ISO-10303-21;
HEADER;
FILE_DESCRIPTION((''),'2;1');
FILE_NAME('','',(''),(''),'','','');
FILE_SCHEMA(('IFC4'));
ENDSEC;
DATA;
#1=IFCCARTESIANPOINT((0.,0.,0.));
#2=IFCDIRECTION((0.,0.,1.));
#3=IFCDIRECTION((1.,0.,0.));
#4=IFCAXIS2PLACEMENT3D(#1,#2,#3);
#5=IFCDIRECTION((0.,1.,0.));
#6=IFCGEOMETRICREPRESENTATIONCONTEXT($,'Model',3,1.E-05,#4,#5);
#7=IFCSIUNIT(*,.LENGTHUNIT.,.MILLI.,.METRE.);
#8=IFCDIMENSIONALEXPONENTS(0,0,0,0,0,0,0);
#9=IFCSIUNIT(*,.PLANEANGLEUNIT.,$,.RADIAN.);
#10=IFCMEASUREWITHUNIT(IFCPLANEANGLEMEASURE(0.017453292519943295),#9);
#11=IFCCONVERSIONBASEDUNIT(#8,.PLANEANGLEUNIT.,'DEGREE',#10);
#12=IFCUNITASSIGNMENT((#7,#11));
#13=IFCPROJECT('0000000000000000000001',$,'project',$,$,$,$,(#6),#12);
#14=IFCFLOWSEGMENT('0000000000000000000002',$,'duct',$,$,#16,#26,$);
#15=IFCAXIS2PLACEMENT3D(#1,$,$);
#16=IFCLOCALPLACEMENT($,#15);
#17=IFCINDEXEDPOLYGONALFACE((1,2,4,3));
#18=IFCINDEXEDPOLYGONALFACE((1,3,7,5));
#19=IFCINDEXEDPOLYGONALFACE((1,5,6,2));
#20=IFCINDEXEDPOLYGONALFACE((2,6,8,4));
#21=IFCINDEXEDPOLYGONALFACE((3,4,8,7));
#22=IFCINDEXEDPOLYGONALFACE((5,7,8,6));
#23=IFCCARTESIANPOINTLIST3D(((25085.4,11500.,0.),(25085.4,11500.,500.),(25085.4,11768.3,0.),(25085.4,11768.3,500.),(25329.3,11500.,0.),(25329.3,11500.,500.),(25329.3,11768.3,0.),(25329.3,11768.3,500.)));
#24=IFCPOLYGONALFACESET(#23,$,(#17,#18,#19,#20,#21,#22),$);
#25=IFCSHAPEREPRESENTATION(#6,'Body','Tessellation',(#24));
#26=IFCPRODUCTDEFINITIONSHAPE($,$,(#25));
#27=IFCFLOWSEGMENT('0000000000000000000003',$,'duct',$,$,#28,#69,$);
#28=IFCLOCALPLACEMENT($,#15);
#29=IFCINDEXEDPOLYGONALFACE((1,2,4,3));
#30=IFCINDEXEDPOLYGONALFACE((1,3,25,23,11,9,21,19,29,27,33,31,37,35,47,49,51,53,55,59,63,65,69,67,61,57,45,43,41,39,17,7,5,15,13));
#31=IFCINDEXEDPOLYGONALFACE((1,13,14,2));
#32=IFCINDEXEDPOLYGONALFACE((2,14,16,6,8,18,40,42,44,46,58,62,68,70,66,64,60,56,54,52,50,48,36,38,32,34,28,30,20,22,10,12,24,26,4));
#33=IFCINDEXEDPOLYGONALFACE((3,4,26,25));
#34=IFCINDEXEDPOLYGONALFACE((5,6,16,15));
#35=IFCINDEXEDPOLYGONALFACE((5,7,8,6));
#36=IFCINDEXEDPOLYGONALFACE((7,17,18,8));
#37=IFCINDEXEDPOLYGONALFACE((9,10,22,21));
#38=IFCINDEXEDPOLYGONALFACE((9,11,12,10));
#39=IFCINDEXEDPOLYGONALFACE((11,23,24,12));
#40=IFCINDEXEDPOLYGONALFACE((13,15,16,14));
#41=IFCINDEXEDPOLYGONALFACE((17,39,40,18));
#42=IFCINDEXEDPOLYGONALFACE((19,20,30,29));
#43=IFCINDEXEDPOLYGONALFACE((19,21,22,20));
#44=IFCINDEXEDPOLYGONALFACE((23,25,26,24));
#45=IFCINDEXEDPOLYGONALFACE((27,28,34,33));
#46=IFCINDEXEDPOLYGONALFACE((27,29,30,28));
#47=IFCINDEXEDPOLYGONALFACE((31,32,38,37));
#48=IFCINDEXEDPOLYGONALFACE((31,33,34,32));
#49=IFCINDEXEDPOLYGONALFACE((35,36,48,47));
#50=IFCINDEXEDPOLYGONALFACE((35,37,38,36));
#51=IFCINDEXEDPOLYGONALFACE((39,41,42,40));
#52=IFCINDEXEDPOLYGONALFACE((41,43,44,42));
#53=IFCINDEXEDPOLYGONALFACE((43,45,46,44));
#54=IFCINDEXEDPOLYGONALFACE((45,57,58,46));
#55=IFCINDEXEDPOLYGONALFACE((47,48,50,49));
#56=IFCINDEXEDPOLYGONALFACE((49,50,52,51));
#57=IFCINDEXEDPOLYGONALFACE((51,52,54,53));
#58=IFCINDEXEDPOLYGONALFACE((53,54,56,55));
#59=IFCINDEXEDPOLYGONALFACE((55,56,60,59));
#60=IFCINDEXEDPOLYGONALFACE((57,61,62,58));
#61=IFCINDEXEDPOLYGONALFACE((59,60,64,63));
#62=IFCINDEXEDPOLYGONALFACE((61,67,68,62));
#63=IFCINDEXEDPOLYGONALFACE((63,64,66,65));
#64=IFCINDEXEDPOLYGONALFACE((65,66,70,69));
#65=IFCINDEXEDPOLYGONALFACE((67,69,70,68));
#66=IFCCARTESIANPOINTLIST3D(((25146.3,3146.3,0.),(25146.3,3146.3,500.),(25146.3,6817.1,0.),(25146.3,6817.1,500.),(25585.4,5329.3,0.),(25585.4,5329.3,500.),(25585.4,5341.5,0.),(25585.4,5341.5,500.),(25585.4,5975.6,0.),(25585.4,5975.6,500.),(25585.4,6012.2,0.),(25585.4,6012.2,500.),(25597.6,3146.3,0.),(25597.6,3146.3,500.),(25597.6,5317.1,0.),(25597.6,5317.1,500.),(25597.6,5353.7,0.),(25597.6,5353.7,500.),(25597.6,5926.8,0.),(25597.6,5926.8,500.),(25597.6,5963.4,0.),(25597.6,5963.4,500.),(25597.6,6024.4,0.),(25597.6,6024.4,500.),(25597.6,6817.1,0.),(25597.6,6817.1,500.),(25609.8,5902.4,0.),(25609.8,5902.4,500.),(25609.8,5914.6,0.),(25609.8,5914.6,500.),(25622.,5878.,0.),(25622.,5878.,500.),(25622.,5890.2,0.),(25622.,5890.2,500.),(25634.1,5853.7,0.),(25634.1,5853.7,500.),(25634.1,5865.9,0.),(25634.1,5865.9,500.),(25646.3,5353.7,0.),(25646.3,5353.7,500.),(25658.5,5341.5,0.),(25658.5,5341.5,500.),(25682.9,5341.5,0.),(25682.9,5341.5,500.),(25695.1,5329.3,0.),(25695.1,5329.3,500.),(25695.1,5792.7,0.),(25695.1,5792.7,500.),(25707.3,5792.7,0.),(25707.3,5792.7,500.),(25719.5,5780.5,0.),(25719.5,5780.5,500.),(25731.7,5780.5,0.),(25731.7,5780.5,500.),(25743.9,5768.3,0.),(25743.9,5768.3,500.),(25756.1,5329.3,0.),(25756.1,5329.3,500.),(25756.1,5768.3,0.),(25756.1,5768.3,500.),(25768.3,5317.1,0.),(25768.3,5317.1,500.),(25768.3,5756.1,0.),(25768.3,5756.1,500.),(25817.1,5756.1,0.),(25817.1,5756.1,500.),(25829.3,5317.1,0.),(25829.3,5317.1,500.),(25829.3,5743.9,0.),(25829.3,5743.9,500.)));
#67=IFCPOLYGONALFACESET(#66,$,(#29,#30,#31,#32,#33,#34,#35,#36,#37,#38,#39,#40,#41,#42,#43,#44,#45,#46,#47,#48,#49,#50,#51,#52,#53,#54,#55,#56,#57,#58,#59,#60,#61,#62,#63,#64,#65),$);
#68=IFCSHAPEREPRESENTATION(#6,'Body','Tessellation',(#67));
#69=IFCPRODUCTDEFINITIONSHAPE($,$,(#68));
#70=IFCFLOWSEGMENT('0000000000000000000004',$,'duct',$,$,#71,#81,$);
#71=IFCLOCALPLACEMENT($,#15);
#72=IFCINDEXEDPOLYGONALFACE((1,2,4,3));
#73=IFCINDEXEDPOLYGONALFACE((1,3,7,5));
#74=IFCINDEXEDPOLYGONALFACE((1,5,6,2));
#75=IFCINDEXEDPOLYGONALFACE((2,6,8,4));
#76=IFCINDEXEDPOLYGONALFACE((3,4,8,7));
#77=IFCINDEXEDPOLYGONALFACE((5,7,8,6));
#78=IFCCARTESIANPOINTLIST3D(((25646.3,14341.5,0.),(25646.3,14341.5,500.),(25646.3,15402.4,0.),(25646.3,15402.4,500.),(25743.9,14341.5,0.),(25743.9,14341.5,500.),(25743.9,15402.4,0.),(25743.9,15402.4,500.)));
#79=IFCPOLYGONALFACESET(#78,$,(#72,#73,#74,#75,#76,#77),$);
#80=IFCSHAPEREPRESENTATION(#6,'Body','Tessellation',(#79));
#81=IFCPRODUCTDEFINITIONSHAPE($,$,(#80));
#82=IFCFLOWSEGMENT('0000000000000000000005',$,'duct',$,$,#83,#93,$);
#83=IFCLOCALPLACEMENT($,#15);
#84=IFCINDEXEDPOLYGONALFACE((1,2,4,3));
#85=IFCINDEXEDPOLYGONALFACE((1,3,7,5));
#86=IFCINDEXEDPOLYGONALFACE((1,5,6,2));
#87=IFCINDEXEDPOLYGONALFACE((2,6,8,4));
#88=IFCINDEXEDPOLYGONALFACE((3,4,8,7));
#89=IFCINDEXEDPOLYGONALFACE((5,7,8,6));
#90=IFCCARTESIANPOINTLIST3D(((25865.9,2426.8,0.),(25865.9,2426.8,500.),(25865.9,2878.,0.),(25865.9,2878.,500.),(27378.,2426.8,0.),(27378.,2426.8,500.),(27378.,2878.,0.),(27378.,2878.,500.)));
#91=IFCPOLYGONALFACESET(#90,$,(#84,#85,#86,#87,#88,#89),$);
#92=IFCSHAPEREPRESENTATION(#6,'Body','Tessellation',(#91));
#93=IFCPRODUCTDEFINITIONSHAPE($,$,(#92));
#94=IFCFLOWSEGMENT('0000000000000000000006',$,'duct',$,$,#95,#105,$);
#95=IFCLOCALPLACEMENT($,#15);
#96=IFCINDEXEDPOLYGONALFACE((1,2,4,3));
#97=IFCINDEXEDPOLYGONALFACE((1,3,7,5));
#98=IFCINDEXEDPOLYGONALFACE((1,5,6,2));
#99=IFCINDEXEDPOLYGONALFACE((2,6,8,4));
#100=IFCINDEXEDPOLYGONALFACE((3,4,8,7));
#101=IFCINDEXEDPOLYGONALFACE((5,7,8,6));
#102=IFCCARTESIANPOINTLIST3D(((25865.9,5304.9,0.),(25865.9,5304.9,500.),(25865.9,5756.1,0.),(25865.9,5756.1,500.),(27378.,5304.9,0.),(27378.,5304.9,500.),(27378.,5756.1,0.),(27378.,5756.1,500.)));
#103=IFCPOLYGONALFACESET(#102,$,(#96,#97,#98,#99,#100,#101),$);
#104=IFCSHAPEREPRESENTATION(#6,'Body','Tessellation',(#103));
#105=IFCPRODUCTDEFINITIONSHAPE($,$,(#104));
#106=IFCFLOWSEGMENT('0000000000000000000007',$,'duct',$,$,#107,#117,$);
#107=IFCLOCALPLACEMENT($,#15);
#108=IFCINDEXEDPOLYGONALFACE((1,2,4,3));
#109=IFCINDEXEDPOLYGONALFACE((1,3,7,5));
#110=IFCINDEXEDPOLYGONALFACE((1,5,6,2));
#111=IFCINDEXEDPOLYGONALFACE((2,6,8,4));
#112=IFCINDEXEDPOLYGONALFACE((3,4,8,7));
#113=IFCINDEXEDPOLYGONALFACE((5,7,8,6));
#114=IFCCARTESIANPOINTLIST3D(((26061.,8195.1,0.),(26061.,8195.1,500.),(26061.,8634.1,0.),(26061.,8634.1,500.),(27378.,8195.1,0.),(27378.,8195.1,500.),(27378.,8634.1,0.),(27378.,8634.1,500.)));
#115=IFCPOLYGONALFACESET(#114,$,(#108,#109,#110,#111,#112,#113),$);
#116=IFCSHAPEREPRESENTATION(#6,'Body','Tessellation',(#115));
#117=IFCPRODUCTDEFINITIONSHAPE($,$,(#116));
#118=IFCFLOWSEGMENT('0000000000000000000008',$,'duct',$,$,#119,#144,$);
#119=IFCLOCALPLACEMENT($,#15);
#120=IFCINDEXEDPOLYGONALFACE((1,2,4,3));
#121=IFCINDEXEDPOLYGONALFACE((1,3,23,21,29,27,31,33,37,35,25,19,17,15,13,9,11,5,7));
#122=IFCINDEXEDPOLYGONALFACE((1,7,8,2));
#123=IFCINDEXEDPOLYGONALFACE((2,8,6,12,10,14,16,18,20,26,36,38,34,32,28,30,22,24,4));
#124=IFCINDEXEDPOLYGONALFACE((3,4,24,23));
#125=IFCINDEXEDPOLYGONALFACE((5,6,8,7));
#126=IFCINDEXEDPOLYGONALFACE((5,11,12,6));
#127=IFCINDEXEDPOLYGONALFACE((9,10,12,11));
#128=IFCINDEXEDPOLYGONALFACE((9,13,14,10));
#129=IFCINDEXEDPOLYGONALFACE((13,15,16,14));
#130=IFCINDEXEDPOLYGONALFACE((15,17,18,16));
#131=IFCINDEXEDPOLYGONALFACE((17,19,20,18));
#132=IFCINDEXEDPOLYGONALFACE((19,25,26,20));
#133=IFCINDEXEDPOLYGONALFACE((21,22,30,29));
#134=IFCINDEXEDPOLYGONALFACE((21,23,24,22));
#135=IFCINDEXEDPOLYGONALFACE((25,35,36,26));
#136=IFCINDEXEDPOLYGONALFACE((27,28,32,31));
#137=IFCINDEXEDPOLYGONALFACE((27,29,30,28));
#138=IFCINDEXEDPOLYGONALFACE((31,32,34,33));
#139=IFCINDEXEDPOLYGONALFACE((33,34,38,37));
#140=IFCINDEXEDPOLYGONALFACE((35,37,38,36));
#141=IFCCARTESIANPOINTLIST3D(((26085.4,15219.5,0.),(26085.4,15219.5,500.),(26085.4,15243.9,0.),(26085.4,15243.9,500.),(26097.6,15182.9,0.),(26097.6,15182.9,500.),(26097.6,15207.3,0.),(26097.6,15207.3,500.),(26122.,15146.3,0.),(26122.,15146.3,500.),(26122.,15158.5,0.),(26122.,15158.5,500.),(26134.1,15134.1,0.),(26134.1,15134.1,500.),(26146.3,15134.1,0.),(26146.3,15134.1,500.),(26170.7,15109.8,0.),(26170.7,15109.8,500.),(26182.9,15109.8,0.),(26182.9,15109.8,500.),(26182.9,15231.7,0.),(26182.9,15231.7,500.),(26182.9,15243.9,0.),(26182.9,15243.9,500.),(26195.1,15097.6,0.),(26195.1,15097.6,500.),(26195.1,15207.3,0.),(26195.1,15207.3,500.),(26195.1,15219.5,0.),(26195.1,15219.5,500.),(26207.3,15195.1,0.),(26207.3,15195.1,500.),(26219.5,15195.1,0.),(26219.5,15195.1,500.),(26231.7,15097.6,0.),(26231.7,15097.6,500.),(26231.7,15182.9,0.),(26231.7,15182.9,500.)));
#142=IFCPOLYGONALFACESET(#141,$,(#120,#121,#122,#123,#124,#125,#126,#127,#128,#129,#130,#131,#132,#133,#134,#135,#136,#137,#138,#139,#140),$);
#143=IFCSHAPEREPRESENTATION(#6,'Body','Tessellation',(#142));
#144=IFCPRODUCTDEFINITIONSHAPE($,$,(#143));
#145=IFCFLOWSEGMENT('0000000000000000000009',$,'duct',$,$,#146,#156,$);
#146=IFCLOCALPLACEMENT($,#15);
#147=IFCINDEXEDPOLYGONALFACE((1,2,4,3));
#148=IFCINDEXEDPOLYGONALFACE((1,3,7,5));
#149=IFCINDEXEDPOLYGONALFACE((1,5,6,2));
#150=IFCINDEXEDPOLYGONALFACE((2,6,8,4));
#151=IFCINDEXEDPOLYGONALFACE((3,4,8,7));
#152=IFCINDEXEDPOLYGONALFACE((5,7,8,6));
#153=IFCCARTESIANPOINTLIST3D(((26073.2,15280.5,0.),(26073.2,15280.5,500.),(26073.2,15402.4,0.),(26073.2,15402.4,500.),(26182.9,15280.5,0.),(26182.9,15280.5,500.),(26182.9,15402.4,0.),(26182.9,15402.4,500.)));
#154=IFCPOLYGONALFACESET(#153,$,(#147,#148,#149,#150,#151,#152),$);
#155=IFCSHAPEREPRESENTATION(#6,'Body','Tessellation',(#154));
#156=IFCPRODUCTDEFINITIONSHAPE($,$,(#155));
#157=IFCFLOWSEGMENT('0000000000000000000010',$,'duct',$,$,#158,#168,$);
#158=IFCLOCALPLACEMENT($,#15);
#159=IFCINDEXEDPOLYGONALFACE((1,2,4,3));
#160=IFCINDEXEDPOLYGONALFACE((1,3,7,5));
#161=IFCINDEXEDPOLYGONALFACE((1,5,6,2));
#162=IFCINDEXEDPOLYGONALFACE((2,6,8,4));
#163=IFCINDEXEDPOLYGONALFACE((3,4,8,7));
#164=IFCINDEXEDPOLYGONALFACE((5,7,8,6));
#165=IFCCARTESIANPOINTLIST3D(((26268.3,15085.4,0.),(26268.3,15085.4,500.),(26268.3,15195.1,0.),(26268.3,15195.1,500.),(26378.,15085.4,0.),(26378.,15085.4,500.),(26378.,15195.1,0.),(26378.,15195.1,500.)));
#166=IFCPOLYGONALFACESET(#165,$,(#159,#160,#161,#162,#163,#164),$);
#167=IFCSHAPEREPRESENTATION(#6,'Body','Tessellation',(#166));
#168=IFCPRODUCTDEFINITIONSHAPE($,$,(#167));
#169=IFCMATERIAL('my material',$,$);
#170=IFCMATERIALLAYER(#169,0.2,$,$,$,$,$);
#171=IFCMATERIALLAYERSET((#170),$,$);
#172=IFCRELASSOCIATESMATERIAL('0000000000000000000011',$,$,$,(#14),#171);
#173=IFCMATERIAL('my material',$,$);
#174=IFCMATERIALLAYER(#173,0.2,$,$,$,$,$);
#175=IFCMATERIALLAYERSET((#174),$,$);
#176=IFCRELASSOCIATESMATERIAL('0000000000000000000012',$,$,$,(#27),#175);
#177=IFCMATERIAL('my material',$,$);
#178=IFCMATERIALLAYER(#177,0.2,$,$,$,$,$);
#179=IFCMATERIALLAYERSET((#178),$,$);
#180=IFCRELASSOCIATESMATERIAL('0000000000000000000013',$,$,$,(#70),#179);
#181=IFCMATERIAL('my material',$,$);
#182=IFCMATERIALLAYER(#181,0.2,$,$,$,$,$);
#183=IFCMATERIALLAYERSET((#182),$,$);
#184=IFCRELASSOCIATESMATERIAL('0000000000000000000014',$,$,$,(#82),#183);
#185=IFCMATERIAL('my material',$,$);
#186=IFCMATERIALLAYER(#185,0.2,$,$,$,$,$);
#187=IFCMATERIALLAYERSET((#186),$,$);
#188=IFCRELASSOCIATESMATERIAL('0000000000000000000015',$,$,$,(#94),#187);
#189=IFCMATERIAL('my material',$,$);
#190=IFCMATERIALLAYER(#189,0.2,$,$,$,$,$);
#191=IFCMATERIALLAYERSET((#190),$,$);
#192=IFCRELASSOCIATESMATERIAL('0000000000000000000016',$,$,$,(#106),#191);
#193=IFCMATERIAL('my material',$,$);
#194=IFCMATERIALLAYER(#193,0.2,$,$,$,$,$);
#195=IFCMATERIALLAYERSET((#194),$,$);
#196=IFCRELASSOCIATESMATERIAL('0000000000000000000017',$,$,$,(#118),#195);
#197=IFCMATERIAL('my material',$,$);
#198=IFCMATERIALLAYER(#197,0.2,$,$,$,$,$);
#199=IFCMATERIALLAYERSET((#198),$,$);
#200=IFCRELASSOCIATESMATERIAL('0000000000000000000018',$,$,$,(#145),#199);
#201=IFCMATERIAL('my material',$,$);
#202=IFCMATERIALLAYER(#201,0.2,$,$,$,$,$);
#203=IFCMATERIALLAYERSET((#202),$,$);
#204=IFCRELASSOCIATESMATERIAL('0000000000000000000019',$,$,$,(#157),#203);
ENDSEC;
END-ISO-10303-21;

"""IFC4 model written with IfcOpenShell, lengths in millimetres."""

from ifc_helpers import new_model, entity, si_unit, converted_unit, direction, origin_with_axes, place, context, project, polyline, outline, extrude, material, layer, layer_set, layer_usage, element, save


model = new_model("IFC4")

# Units and contexts
model_context = context("Model", 3, precision=1e-05, world=origin_with_axes(), true_north=direction((0.0, 1.0, 0.0)))
ifc_project = project(units=[si_unit("LENGTHUNIT", "METRE", prefix="MILLI"), converted_unit("PLANEANGLEUNIT", "DEGREE", entity("IfcPlaneAngleMeasure", 0.017453292519943295), si_unit("PLANEANGLEUNIT", "RADIAN"), dimensions=[0, 0, 0, 0, 0, 0, 0])], contexts=[model_context])

# Flow segments
ifc_material_1 = material(Name="my material")
ifc_layer_1 = layer(ifc_material_1, 0.2)
ifc_layer_set_1 = layer_set([ifc_layer_1])
ifc_layer_usage_1 = layer_usage(ifc_layer_set_1, "AXIS2", "POSITIVE", -0.1)
flow_segment_1_placement = place(None, origin_with_axes())
element("IfcFlowSegment", 1, at=flow_segment_1_placement, material=ifc_layer_usage_1, Name="duct", context=model_context, shape_type="SweptSolid", body=[
    extrude(outline(polyline([(25085.4, 11500.0), (25329.3, 11500.0), (25329.3, 11768.3), (25085.4, 11768.3), (25085.4, 11500.0)])), origin_with_axes(), (0.0, 0.0, 1.0), 500.0),
])
ifc_material_2 = material(Name="my material")
ifc_layer_2 = layer(ifc_material_2, 0.2)
ifc_layer_set_2 = layer_set([ifc_layer_2])
ifc_layer_usage_2 = layer_usage(ifc_layer_set_2, "AXIS2", "POSITIVE", -0.1)
flow_segment_2_placement = place(None, origin_with_axes())
element("IfcFlowSegment", 2, at=flow_segment_2_placement, material=ifc_layer_usage_2, Name="duct", context=model_context, shape_type="SweptSolid", body=[
    extrude(outline(polyline([(25146.3, 3146.3), (25597.6, 3146.3), (25597.6, 5317.1), (25585.4, 5329.3), (25585.4, 5341.5), (25597.6, 5353.7), (25646.3, 5353.7), (25658.5, 5341.5), (25682.9, 5341.5), (25695.1, 5329.3), (25756.1, 5329.3), (25768.3, 5317.1), (25829.3, 5317.1), (25829.3, 5743.9), (25817.1, 5756.1), (25768.3, 5756.1), (25756.1, 5768.3), (25743.9, 5768.3), (25731.7, 5780.5), (25719.5, 5780.5), (25707.3, 5792.7), (25695.1, 5792.7), (25634.1, 5853.7), (25634.1, 5865.9), (25622.0, 5878.0), (25622.0, 5890.2), (25609.8, 5902.4), (25609.8, 5914.6), (25597.6, 5926.8), (25597.6, 5963.4), (25585.4, 5975.6), (25585.4, 6012.2), (25597.6, 6024.4), (25597.6, 6817.1), (25146.3, 6817.1), (25146.3, 3146.3)])), origin_with_axes(), (0.0, 0.0, 1.0), 500.0),
])
ifc_material_3 = material(Name="my material")
ifc_layer_3 = layer(ifc_material_3, 0.2)
ifc_layer_set_3 = layer_set([ifc_layer_3])
ifc_layer_usage_3 = layer_usage(ifc_layer_set_3, "AXIS2", "POSITIVE", -0.1)
flow_segment_3_placement = place(None, origin_with_axes())
element("IfcFlowSegment", 3, at=flow_segment_3_placement, material=ifc_layer_usage_3, Name="duct", context=model_context, shape_type="SweptSolid", body=[
    extrude(outline(polyline([(25646.3, 14341.5), (25743.9, 14341.5), (25743.9, 15402.4), (25646.3, 15402.4), (25646.3, 14341.5)])), origin_with_axes(), (0.0, 0.0, 1.0), 500.0),
])
ifc_material_4 = material(Name="my material")
ifc_layer_4 = layer(ifc_material_4, 0.2)
ifc_layer_set_4 = layer_set([ifc_layer_4])
ifc_layer_usage_4 = layer_usage(ifc_layer_set_4, "AXIS2", "POSITIVE", -0.1)
flow_segment_4_placement = place(None, origin_with_axes())
element("IfcFlowSegment", 4, at=flow_segment_4_placement, material=ifc_layer_usage_4, Name="duct", context=model_context, shape_type="SweptSolid", body=[
    extrude(outline(polyline([(25865.9, 2426.8), (27378.0, 2426.8), (27378.0, 2878.0), (25865.9, 2878.0), (25865.9, 2426.8)])), origin_with_axes(), (0.0, 0.0, 1.0), 500.0),
])
ifc_material_5 = material(Name="my material")
ifc_layer_5 = layer(ifc_material_5, 0.2)
ifc_layer_set_5 = layer_set([ifc_layer_5])
ifc_layer_usage_5 = layer_usage(ifc_layer_set_5, "AXIS2", "POSITIVE", -0.1)
flow_segment_5_placement = place(None, origin_with_axes())
element("IfcFlowSegment", 5, at=flow_segment_5_placement, material=ifc_layer_usage_5, Name="duct", context=model_context, shape_type="SweptSolid", body=[
    extrude(outline(polyline([(25865.9, 5304.9), (27378.0, 5304.9), (27378.0, 5756.1), (25865.9, 5756.1), (25865.9, 5304.9)])), origin_with_axes(), (0.0, 0.0, 1.0), 500.0),
])
ifc_material_6 = material(Name="my material")
ifc_layer_6 = layer(ifc_material_6, 0.2)
ifc_layer_set_6 = layer_set([ifc_layer_6])
ifc_layer_usage_6 = layer_usage(ifc_layer_set_6, "AXIS2", "POSITIVE", -0.1)
flow_segment_6_placement = place(None, origin_with_axes())
element("IfcFlowSegment", 6, at=flow_segment_6_placement, material=ifc_layer_usage_6, Name="duct", context=model_context, shape_type="SweptSolid", body=[
    extrude(outline(polyline([(26061.0, 8195.1), (27378.0, 8195.1), (27378.0, 8634.1), (26061.0, 8634.1), (26061.0, 8195.1)])), origin_with_axes(), (0.0, 0.0, 1.0), 500.0),
])
ifc_material_7 = material(Name="my material")
ifc_layer_7 = layer(ifc_material_7, 0.2)
ifc_layer_set_7 = layer_set([ifc_layer_7])
ifc_layer_usage_7 = layer_usage(ifc_layer_set_7, "AXIS2", "POSITIVE", -0.1)
flow_segment_7_placement = place(None, origin_with_axes())
element("IfcFlowSegment", 7, at=flow_segment_7_placement, material=ifc_layer_usage_7, Name="duct", context=model_context, shape_type="SweptSolid", body=[
    extrude(outline(polyline([(26085.4, 15219.5), (26097.6, 15207.3), (26097.6, 15182.9), (26122.0, 15158.5), (26122.0, 15146.3), (26134.1, 15134.1), (26146.3, 15134.1), (26170.7, 15109.8), (26182.9, 15109.8), (26195.1, 15097.6), (26231.7, 15097.6), (26231.7, 15182.9), (26219.5, 15195.1), (26207.3, 15195.1), (26195.1, 15207.3), (26195.1, 15219.5), (26182.9, 15231.7), (26182.9, 15243.9), (26085.4, 15243.9), (26085.4, 15219.5)])), origin_with_axes(), (0.0, 0.0, 1.0), 500.0),
])
ifc_material_8 = material(Name="my material")
ifc_layer_8 = layer(ifc_material_8, 0.2)
ifc_layer_set_8 = layer_set([ifc_layer_8])
ifc_layer_usage_8 = layer_usage(ifc_layer_set_8, "AXIS2", "POSITIVE", -0.1)
flow_segment_8_placement = place(None, origin_with_axes())
element("IfcFlowSegment", 8, at=flow_segment_8_placement, material=ifc_layer_usage_8, Name="duct", context=model_context, shape_type="SweptSolid", body=[
    extrude(outline(polyline([(26073.2, 15280.5), (26182.9, 15280.5), (26182.9, 15402.4), (26073.2, 15402.4), (26073.2, 15280.5)])), origin_with_axes(), (0.0, 0.0, 1.0), 500.0),
])
ifc_material_9 = material(Name="my material")
ifc_layer_9 = layer(ifc_material_9, 0.2)
ifc_layer_set_9 = layer_set([ifc_layer_9])
ifc_layer_usage_9 = layer_usage(ifc_layer_set_9, "AXIS2", "POSITIVE", -0.1)
flow_segment_9_placement = place(None, origin_with_axes())
element("IfcFlowSegment", 9, at=flow_segment_9_placement, material=ifc_layer_usage_9, Name="duct", context=model_context, shape_type="SweptSolid", body=[
    extrude(outline(polyline([(26268.3, 15085.4), (26378.0, 15085.4), (26378.0, 15195.1), (26268.3, 15195.1), (26268.3, 15085.4)])), origin_with_axes(), (0.0, 0.0, 1.0), 500.0),
])

save(model, "model.ifc")
